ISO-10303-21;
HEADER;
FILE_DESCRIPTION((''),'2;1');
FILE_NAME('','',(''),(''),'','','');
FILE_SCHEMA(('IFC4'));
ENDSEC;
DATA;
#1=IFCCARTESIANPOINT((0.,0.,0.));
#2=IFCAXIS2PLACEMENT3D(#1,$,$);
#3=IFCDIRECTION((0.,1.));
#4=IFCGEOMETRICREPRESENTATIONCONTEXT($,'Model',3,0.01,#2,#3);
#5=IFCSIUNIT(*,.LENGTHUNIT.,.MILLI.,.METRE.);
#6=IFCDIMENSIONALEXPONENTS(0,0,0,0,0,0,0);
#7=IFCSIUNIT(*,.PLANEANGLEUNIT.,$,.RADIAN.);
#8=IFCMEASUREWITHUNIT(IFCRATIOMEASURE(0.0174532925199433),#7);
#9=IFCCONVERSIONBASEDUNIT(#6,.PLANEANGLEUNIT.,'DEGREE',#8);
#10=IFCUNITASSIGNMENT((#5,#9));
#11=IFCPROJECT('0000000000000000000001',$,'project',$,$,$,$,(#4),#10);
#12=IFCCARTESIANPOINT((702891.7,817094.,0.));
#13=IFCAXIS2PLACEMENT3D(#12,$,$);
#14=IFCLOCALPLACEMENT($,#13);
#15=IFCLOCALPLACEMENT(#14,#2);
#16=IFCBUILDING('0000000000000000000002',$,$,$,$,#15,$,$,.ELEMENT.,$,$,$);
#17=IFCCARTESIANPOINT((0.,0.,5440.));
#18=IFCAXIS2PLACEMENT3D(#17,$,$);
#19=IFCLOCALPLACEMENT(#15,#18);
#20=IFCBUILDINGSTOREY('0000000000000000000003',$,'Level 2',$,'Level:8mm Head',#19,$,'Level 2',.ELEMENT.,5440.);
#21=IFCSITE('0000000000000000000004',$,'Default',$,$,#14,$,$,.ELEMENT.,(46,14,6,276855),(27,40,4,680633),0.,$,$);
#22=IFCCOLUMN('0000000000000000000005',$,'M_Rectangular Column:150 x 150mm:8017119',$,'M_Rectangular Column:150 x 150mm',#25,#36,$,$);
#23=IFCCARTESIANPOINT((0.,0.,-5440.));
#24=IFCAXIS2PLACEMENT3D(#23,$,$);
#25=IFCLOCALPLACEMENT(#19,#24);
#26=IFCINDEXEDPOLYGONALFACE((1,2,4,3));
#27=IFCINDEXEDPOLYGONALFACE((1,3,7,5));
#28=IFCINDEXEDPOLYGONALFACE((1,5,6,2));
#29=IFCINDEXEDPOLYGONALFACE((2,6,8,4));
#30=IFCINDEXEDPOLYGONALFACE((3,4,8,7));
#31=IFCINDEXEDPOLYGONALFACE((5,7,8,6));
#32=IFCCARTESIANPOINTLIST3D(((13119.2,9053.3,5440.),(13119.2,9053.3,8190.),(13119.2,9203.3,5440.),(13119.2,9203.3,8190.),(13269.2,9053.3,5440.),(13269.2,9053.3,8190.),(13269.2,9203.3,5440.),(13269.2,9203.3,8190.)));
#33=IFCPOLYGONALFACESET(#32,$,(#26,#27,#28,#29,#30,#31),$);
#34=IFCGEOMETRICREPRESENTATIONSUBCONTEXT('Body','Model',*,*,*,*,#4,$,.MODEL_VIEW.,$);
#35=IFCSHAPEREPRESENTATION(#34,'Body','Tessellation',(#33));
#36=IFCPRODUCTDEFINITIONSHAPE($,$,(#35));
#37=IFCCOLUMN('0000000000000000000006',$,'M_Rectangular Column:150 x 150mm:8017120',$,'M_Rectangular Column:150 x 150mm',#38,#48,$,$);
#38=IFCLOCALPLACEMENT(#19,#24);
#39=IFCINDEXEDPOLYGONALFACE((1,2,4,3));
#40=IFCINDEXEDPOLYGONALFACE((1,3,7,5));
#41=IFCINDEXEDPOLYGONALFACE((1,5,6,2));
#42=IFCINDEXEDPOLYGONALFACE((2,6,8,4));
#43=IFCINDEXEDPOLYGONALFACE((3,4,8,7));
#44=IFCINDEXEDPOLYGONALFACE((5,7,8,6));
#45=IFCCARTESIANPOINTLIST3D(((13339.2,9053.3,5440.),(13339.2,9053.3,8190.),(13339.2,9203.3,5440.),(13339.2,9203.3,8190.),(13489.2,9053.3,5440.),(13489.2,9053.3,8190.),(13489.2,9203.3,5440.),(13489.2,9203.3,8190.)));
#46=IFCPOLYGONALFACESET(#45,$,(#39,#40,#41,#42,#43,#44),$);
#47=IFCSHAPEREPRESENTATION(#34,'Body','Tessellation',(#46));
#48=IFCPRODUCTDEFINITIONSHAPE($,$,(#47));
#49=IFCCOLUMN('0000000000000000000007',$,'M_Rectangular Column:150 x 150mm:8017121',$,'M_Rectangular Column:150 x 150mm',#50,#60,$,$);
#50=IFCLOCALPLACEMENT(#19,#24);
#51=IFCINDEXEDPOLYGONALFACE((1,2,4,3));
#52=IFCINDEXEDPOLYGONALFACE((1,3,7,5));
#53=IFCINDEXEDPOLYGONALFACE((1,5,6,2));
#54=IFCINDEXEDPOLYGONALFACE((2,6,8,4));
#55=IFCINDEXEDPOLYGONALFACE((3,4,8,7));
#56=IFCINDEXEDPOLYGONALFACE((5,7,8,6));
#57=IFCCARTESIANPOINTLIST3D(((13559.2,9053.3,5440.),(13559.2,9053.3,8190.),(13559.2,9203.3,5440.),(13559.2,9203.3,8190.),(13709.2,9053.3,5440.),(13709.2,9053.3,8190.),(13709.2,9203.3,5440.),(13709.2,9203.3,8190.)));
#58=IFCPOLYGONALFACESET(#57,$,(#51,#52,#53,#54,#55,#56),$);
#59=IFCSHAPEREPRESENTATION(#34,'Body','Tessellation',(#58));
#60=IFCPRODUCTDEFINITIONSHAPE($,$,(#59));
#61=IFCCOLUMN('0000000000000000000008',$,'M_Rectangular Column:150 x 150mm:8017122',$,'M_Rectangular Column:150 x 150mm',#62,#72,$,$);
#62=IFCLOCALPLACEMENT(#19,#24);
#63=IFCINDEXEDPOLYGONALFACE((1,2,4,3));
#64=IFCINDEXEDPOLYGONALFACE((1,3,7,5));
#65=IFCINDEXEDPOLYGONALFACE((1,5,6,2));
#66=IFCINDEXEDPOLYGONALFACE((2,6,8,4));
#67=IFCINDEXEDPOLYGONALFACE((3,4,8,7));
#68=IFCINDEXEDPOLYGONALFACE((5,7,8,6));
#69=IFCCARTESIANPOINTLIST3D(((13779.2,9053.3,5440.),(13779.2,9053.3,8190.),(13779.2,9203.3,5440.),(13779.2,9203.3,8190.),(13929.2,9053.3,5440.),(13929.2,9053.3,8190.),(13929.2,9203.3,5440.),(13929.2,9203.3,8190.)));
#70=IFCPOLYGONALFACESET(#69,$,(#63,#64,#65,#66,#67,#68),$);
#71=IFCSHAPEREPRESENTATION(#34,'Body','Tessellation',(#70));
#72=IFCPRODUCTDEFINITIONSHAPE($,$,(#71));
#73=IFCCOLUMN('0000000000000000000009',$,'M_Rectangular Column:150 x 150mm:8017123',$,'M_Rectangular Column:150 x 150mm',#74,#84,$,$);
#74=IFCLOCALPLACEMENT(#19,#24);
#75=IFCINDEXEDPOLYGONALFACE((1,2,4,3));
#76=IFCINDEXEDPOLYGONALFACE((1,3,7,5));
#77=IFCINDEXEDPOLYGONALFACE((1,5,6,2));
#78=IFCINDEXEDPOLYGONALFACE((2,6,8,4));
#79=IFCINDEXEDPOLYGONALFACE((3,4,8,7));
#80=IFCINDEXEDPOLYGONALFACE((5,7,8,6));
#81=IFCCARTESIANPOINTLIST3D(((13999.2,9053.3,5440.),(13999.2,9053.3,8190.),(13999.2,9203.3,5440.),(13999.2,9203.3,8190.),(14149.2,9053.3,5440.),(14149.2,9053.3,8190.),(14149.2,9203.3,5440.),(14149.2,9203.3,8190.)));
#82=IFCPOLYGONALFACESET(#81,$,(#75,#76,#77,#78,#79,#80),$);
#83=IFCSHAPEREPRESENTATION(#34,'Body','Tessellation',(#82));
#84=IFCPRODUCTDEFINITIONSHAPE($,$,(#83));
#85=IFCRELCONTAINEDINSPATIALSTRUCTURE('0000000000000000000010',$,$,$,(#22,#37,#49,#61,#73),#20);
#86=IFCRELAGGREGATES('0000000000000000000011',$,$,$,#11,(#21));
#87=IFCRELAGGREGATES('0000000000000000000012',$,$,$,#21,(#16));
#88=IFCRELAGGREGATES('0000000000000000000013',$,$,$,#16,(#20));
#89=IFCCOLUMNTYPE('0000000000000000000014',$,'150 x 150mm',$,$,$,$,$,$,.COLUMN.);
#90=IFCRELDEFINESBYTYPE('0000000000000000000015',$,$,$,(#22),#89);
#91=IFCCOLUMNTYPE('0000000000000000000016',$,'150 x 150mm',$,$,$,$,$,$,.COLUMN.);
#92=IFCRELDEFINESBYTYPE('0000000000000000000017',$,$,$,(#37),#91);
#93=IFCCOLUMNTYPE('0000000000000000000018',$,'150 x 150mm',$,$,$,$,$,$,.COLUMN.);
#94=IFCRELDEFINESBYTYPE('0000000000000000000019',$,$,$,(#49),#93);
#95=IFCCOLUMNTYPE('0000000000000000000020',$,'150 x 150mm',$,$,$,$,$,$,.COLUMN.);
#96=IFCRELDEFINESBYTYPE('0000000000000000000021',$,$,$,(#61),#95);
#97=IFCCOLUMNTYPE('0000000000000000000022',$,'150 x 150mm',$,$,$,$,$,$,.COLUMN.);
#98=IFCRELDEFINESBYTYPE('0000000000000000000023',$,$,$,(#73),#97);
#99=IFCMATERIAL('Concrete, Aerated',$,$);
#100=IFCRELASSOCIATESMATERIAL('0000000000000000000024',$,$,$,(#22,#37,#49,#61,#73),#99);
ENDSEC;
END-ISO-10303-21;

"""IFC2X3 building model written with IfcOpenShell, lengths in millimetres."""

from ifc_helpers import new_model, entity, si_unit, converted_unit, direction, frame, frame_2d, origin, place, context, subcontext, project, spatial, rectangle, extrude, source, transform, mapped, material, type_object, type_shapes, element, save


model = new_model("IFC2X3")

# Units and contexts
model_context = context("Model", 3, precision=0.01, world=origin(), true_north=direction((0.0, 1.0)))
body_context = subcontext(model_context, "Body", "Model", "MODEL_VIEW")
ifc_project = project(units=[si_unit("LENGTHUNIT", "METRE", prefix="MILLI"), converted_unit("PLANEANGLEUNIT", "DEGREE", entity("IfcRatioMeasure", 0.0174532925199433), si_unit("PLANEANGLEUNIT", "RADIAN"), dimensions=[0, 0, 0, 0, 0, 0, 0])], contexts=[model_context])

# Site, building, storey
site_placement = place(None, frame((702891.7, 817094.0, 0.0)))
site = spatial("IfcSite", under=ifc_project, at=site_placement, Name="Default", CompositionType="ELEMENT", RefLatitude=(46, 14, 6, 276855), RefLongitude=(27, 40, 4, 680633), RefElevation=0.0)
building_placement = place(site_placement, origin())
building = spatial("IfcBuilding", under=site, at=building_placement, CompositionType="ELEMENT")
storey_placement = place(building_placement, frame((0.0, 0.0, 5440.0)))
storey = spatial("IfcBuildingStorey", under=building, at=storey_placement, Name="Level 2", ObjectType="Level:8mm Head", LongName="Level 2", CompositionType="ELEMENT", Elevation=5440.0)

# Columns
ifc_material_1 = material(Name="Concrete, Aerated")
column_type_1 = type_object("IfcColumnType", Name="150 x 150mm", PredefinedType="COLUMN")
shared_shape_1 = source(origin(), body_context, "Body", "SweptSolid", [
    extrude(rectangle(XDim=150.0, YDim=150.0, at=frame_2d((0.0, 0.0), x_axis=(1.0, 0.0))), frame((13194.2, 9128.3, 5440.0), z_axis=(0.0, 0.0, 1.0), x_axis=(0.0, -1.0, 0.0)), (0.0, 0.0, 1.0), 2750.0),
])
type_shapes(column_type_1, [shared_shape_1])
column_1_placement = place(storey_placement, frame((0.0, 0.0, -5440.0)))
element("IfcColumn", 1, at=column_1_placement, inside=storey, type_object=column_type_1, material=ifc_material_1, Name="M_Rectangular Column:150 x 150mm:8017119", ObjectType="M_Rectangular Column:150 x 150mm", context=body_context, shape_type="MappedRepresentation", body=[
    mapped(shared_shape_1, transform((0.0, 0.0, 0.0), scale=1.0)),
])
column_type_2 = type_object("IfcColumnType", Name="150 x 150mm", PredefinedType="COLUMN")
shared_shape_2 = source(origin(), body_context, "Body", "SweptSolid", [
    extrude(rectangle(XDim=150.0, YDim=150.0, at=frame_2d((0.0, 0.0), x_axis=(1.0, 0.0))), frame((13414.2, 9128.3, 5440.0), z_axis=(0.0, 0.0, 1.0), x_axis=(0.0, -1.0, 0.0)), (0.0, 0.0, 1.0), 2750.0),
])
type_shapes(column_type_2, [shared_shape_2])
column_2_placement = place(storey_placement, frame((0.0, 0.0, -5440.0)))
element("IfcColumn", 2, at=column_2_placement, inside=storey, type_object=column_type_2, material=ifc_material_1, Name="M_Rectangular Column:150 x 150mm:8017120", ObjectType="M_Rectangular Column:150 x 150mm", context=body_context, shape_type="MappedRepresentation", body=[
    mapped(shared_shape_2, transform((0.0, 0.0, 0.0), scale=1.0)),
])
column_type_3 = type_object("IfcColumnType", Name="150 x 150mm", PredefinedType="COLUMN")
shared_shape_3 = source(origin(), body_context, "Body", "SweptSolid", [
    extrude(rectangle(XDim=150.0, YDim=150.0, at=frame_2d((0.0, 0.0), x_axis=(1.0, 0.0))), frame((13634.2, 9128.3, 5440.0), z_axis=(0.0, 0.0, 1.0), x_axis=(0.0, -1.0, 0.0)), (0.0, 0.0, 1.0), 2750.0),
])
type_shapes(column_type_3, [shared_shape_3])
column_3_placement = place(storey_placement, frame((0.0, 0.0, -5440.0)))
element("IfcColumn", 3, at=column_3_placement, inside=storey, type_object=column_type_3, material=ifc_material_1, Name="M_Rectangular Column:150 x 150mm:8017121", ObjectType="M_Rectangular Column:150 x 150mm", context=body_context, shape_type="MappedRepresentation", body=[
    mapped(shared_shape_3, transform((0.0, 0.0, 0.0), scale=1.0)),
])
column_type_4 = type_object("IfcColumnType", Name="150 x 150mm", PredefinedType="COLUMN")
shared_shape_4 = source(origin(), body_context, "Body", "SweptSolid", [
    extrude(rectangle(XDim=150.0, YDim=150.0, at=frame_2d((0.0, 0.0), x_axis=(1.0, 0.0))), frame((13854.2, 9128.3, 5440.0), z_axis=(0.0, 0.0, 1.0), x_axis=(0.0, -1.0, 0.0)), (0.0, 0.0, 1.0), 2750.0),
])
type_shapes(column_type_4, [shared_shape_4])
column_4_placement = place(storey_placement, frame((0.0, 0.0, -5440.0)))
element("IfcColumn", 4, at=column_4_placement, inside=storey, type_object=column_type_4, material=ifc_material_1, Name="M_Rectangular Column:150 x 150mm:8017122", ObjectType="M_Rectangular Column:150 x 150mm", context=body_context, shape_type="MappedRepresentation", body=[
    mapped(shared_shape_4, transform((0.0, 0.0, 0.0), scale=1.0)),
])
column_type_5 = type_object("IfcColumnType", Name="150 x 150mm", PredefinedType="COLUMN")
shared_shape_5 = source(origin(), body_context, "Body", "SweptSolid", [
    extrude(rectangle(XDim=150.0, YDim=150.0, at=frame_2d((0.0, 0.0), x_axis=(1.0, 0.0))), frame((14074.2, 9128.3, 5440.0), z_axis=(0.0, 0.0, 1.0), x_axis=(0.0, -1.0, 0.0)), (0.0, 0.0, 1.0), 2750.0),
])
type_shapes(column_type_5, [shared_shape_5])
column_5_placement = place(storey_placement, frame((0.0, 0.0, -5440.0)))
element("IfcColumn", 5, at=column_5_placement, inside=storey, type_object=column_type_5, material=ifc_material_1, Name="M_Rectangular Column:150 x 150mm:8017123", ObjectType="M_Rectangular Column:150 x 150mm", context=body_context, shape_type="MappedRepresentation", body=[
    mapped(shared_shape_5, transform((0.0, 0.0, 0.0), scale=1.0)),
])

save(model, "model.ifc")
